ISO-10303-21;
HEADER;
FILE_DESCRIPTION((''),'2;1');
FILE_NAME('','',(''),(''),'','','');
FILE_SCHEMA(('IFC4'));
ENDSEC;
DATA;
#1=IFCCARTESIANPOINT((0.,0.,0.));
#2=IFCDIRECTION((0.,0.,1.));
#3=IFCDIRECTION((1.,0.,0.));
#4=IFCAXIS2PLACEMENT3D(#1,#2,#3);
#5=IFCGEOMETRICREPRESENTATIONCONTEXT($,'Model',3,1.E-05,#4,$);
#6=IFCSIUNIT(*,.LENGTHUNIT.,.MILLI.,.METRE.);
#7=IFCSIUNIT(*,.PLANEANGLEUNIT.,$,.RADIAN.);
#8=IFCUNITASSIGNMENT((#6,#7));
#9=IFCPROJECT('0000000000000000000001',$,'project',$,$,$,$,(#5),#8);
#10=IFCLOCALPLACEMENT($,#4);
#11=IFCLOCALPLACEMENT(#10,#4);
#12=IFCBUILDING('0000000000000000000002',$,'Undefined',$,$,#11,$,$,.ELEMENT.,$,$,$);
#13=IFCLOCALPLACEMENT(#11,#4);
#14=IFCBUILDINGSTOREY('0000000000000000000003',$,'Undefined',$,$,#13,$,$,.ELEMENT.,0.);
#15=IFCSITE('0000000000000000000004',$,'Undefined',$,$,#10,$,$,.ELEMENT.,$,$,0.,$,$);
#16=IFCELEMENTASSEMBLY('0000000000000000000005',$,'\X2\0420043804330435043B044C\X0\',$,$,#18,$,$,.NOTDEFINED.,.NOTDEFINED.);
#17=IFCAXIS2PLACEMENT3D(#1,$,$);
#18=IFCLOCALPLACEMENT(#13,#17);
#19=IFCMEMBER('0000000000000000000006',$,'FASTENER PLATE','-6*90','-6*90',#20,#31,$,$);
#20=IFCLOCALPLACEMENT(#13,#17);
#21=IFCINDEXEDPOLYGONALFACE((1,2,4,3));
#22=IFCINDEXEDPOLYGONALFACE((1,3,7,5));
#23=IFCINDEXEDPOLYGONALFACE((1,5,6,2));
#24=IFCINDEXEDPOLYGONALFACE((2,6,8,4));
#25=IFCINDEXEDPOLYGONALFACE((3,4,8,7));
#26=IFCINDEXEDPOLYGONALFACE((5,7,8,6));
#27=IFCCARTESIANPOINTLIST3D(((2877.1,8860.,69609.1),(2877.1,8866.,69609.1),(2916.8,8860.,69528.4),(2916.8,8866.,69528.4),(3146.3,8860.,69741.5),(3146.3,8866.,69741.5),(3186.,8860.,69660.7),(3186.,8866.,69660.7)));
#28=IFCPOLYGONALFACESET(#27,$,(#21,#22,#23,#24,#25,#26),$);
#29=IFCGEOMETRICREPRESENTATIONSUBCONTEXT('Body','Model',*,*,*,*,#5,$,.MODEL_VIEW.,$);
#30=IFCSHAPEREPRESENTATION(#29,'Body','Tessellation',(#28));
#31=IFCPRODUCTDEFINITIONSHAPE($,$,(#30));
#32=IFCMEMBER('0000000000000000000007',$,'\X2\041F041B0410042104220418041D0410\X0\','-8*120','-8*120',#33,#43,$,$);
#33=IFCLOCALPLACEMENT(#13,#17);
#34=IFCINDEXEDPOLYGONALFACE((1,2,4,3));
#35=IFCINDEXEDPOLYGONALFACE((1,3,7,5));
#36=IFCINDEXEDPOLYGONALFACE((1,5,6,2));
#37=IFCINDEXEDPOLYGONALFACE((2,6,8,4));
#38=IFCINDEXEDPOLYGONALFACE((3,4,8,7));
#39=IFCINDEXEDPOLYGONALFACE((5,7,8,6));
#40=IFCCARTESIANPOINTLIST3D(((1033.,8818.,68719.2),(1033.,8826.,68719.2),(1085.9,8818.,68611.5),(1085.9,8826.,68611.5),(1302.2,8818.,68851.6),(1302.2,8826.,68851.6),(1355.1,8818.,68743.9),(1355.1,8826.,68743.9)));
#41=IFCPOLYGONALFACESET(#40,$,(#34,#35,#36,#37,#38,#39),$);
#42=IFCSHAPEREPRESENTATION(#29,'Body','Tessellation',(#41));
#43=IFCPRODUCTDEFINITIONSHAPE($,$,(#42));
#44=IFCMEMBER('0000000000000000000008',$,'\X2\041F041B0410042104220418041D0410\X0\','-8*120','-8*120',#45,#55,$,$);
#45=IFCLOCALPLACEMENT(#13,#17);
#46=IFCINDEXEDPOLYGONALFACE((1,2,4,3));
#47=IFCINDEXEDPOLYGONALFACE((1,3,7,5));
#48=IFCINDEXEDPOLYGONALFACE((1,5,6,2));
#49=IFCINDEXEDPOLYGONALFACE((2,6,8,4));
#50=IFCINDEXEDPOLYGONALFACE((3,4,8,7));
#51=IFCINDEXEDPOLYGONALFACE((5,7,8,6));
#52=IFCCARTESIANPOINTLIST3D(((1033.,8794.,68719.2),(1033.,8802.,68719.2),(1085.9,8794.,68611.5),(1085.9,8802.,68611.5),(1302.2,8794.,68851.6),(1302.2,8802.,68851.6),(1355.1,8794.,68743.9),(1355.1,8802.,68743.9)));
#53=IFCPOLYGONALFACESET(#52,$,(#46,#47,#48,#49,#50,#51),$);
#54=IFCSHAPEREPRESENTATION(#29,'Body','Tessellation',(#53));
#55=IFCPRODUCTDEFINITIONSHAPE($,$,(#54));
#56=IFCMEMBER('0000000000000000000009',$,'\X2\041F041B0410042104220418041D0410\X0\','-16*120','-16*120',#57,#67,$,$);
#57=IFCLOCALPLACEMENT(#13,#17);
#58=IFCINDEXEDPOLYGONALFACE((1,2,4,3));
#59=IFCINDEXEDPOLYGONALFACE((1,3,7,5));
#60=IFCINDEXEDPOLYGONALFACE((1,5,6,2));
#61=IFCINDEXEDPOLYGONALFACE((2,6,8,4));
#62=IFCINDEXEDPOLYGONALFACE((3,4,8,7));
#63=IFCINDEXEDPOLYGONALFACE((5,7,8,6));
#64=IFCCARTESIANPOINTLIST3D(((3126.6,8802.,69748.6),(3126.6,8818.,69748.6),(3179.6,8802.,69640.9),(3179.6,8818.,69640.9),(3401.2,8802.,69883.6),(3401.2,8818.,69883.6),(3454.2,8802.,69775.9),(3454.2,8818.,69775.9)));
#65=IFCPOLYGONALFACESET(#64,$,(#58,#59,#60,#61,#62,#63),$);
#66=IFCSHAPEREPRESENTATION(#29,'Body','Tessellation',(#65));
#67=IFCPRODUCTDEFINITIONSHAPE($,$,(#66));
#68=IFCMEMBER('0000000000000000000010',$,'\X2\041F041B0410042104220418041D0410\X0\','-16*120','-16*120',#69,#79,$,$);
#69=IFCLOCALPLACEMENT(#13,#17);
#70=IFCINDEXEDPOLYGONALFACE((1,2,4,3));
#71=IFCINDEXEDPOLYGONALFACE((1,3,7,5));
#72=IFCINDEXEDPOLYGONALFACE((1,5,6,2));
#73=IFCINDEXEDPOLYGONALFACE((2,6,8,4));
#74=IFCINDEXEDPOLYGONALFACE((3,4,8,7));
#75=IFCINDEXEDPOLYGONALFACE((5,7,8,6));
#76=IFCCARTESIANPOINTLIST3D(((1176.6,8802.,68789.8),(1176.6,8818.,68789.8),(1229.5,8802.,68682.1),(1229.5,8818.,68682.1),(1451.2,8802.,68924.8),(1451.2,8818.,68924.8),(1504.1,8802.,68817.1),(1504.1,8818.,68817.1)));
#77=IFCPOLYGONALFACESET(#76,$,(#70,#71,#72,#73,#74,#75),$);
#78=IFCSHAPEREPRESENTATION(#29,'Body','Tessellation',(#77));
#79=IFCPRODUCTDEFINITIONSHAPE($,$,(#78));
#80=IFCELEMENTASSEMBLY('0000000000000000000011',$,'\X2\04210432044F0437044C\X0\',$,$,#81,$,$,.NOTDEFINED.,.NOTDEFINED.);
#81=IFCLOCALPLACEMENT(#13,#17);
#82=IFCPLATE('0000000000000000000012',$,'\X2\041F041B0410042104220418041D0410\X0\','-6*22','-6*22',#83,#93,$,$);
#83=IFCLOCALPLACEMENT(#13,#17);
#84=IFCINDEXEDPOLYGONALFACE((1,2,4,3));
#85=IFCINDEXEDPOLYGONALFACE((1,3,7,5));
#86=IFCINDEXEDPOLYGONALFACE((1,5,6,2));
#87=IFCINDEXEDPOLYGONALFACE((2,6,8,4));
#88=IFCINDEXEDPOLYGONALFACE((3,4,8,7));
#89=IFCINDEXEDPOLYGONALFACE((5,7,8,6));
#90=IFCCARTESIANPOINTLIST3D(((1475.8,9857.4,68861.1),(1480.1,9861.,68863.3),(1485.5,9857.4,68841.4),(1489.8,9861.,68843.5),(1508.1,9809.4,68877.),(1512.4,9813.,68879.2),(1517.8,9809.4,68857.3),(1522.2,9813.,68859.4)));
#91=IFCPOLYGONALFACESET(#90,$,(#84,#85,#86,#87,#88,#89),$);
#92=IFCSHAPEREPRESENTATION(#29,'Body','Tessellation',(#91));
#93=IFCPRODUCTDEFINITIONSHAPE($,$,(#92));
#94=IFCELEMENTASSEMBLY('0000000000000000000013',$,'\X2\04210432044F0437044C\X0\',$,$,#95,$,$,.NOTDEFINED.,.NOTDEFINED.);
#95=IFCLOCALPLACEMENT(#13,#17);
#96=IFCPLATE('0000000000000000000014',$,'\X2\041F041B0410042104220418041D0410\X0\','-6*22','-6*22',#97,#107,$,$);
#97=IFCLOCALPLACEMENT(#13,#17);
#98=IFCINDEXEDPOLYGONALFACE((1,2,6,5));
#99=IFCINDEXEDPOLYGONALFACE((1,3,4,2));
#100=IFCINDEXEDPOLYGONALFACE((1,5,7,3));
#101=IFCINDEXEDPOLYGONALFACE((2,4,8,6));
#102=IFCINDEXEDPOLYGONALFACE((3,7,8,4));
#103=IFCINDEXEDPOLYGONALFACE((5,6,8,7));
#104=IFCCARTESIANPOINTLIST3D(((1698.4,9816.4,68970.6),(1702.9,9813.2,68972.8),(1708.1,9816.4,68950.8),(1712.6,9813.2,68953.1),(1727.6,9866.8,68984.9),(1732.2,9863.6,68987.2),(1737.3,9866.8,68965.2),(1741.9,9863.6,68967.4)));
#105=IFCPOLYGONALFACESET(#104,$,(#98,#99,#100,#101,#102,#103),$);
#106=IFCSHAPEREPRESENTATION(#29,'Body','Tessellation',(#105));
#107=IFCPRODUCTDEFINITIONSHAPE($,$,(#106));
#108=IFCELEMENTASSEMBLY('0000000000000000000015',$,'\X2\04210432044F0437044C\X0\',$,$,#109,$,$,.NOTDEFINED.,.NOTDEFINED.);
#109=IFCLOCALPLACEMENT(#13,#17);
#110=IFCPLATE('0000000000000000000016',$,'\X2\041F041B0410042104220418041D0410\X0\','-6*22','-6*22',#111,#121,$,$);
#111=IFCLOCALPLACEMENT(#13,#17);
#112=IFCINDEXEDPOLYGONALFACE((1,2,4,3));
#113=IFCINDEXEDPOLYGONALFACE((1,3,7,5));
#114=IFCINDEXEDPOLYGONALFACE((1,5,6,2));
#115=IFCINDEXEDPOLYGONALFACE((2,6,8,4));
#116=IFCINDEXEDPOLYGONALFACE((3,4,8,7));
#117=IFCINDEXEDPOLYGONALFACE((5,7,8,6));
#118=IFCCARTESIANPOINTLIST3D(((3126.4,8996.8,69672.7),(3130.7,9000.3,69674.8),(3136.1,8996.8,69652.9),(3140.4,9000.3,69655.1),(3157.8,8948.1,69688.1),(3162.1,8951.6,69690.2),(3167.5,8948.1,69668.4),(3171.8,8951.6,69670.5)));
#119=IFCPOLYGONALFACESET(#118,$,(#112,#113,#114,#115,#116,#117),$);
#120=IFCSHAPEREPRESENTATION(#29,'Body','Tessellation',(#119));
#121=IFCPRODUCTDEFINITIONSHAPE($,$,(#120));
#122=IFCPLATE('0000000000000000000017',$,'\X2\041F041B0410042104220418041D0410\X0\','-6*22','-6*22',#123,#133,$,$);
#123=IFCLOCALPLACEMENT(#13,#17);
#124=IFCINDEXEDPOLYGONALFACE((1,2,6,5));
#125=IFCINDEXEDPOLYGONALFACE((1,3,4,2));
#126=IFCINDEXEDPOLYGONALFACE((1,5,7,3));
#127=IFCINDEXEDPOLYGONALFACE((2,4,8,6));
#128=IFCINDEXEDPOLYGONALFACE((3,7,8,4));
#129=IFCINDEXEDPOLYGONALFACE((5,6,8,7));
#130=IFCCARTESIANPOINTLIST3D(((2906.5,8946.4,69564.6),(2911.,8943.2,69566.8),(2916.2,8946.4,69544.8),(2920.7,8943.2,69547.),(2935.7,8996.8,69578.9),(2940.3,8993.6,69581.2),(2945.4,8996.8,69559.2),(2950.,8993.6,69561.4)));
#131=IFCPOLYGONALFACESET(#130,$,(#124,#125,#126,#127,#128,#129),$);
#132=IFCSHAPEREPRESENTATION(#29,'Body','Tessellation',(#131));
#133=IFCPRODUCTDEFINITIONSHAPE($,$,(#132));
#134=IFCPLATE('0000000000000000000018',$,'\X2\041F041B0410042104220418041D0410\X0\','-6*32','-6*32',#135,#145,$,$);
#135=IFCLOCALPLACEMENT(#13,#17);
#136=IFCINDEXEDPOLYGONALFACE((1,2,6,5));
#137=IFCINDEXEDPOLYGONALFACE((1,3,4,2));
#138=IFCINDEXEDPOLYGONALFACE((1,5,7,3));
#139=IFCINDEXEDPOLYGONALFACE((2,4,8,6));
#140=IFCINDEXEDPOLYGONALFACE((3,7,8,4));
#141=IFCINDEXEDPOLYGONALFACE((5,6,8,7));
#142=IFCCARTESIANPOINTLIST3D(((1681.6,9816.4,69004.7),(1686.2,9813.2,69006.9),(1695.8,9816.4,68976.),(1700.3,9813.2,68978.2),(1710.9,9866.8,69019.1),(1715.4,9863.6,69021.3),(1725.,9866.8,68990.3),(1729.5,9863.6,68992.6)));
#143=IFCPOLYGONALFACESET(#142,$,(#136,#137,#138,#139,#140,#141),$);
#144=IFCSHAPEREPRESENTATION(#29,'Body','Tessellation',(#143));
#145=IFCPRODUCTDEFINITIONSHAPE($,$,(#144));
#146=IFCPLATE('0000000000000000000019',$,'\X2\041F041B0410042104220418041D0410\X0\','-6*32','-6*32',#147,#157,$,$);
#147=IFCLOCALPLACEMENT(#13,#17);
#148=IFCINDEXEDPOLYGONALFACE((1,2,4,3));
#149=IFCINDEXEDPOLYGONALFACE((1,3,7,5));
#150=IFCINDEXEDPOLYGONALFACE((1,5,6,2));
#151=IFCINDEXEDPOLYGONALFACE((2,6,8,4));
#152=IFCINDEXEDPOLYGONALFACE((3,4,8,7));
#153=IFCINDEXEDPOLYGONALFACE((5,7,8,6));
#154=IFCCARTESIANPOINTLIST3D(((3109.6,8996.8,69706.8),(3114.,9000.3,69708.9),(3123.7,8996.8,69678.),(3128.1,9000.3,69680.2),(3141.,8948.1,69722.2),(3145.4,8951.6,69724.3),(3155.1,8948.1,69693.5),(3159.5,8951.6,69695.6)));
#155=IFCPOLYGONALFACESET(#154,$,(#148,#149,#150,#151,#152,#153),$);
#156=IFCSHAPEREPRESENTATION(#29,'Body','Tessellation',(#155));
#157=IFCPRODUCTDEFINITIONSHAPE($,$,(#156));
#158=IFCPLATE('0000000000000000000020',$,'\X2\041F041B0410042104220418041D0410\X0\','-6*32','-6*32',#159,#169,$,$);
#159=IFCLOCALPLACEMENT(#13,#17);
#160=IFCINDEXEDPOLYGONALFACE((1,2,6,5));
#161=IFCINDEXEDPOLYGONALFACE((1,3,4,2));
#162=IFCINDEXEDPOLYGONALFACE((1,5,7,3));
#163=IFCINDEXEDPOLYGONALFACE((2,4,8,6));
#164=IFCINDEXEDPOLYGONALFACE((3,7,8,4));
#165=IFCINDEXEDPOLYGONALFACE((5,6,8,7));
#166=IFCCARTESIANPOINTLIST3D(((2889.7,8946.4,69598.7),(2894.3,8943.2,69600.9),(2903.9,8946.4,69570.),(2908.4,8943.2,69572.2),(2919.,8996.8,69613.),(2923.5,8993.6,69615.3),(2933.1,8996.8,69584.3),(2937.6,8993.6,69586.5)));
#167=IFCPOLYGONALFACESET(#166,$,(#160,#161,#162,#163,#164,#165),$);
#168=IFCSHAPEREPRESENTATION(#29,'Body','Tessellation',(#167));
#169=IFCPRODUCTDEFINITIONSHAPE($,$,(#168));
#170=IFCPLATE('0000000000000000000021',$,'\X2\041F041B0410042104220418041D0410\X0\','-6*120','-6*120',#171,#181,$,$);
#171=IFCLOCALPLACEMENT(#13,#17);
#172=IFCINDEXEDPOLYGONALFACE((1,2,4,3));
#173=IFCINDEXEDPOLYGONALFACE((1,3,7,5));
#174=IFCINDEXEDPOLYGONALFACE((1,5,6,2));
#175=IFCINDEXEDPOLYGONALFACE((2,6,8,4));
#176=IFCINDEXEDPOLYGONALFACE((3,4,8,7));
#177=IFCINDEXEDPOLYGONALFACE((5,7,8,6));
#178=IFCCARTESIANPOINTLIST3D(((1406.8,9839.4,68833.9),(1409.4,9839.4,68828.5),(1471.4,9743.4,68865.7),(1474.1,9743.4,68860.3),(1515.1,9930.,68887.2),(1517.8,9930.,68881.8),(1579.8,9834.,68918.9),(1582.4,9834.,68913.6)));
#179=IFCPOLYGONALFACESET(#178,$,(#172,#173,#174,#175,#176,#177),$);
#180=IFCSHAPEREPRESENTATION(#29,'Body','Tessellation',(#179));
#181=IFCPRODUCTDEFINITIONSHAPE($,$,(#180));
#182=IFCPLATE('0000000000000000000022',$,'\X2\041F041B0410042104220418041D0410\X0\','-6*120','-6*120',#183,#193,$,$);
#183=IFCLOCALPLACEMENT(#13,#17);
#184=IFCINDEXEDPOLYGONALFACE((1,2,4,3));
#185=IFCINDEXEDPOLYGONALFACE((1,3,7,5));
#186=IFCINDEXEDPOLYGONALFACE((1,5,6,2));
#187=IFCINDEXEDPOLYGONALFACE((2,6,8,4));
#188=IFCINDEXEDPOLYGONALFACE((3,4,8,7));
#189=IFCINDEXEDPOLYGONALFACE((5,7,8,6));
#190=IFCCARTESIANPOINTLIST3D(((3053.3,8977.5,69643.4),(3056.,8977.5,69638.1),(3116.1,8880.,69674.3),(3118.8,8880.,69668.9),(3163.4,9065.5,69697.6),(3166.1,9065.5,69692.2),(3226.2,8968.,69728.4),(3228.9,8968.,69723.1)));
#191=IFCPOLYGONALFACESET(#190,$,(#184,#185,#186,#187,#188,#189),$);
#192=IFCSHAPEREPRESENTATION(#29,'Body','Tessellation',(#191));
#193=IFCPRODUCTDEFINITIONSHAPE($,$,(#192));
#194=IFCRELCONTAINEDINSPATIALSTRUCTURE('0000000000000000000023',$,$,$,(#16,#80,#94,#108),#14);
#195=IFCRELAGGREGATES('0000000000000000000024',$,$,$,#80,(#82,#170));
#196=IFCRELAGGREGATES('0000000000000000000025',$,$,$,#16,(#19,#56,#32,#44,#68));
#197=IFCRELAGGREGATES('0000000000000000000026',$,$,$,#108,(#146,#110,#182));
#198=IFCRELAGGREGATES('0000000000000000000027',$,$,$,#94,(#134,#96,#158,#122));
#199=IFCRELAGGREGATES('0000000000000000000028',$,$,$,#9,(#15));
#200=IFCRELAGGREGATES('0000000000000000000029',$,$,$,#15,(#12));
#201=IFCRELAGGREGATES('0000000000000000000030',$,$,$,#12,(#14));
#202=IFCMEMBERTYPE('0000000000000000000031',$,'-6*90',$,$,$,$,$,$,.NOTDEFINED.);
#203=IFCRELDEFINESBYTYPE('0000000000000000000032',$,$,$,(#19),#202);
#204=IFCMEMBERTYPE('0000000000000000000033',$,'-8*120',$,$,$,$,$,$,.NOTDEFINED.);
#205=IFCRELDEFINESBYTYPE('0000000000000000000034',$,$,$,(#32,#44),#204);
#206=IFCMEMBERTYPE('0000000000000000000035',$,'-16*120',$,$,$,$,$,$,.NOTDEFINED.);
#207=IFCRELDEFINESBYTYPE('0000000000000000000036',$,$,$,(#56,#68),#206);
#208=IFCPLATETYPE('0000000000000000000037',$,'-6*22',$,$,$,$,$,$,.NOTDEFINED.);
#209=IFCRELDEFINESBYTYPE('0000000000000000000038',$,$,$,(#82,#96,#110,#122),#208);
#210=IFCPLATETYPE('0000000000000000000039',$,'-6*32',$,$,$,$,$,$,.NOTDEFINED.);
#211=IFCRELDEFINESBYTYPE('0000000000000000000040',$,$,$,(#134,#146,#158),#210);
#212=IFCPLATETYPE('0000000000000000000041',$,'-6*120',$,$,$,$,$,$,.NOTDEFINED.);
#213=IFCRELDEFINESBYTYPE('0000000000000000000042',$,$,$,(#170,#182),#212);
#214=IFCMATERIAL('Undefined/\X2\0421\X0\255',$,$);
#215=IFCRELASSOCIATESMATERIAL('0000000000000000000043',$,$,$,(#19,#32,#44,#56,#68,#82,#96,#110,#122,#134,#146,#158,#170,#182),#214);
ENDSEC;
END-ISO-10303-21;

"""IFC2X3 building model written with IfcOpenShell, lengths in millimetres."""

from ifc_helpers import new_model, si_unit, frame, origin_with_axes, origin_2d_with_axis, place, context, subcontext, project, spatial, polyline, rectangle, outline, extrude, material, type_object, element, aggregate, save


model = new_model("IFC2X3")

# Units and contexts
model_context = context("Model", 3, precision=1e-05, world=origin_with_axes())
body_context = subcontext(model_context, "Body", "Model", "MODEL_VIEW")
ifc_project = project(units=[si_unit("LENGTHUNIT", "METRE", prefix="MILLI"), si_unit("PLANEANGLEUNIT", "RADIAN")], contexts=[model_context])

# Site, building, storey
site_placement = place(None, origin_with_axes())
site = spatial("IfcSite", under=ifc_project, at=site_placement, Name="Undefined", CompositionType="ELEMENT", RefElevation=0.0)
building_placement = place(site_placement, origin_with_axes())
building = spatial("IfcBuilding", under=site, at=building_placement, Name="Undefined", CompositionType="ELEMENT")
storey_placement = place(building_placement, origin_with_axes())
storey = spatial("IfcBuildingStorey", under=building, at=storey_placement, Name="Undefined", CompositionType="ELEMENT", Elevation=0.0)

# Element assembly, members
assembly_1_placement = place(storey_placement, origin_with_axes())
assembly_1 = element("IfcElementAssembly", 1, at=assembly_1_placement, inside=storey, Name="Ригель", AssemblyPlace="NOTDEFINED", PredefinedType="NOTDEFINED")
ifc_material_1 = material(Name="Undefined/С255")
member_type_1 = type_object("IfcMemberType", Name="-6*90", PredefinedType="NOTDEFINED")
member_1_placement = place(assembly_1_placement, frame((2896.9, 8863.0, 69568.8), z_axis=(-0.441224, 0.0, 0.897397), x_axis=(0.897397, 0.0, 0.441224)))
member_1 = element("IfcMember", 2, at=member_1_placement, type_object=member_type_1, material=ifc_material_1, Name="FASTENER PLATE", Description="-6*90", ObjectType="-6*90", context=body_context, shape_type="SweptSolid", body=[
    extrude(rectangle(XDim=6.0, YDim=90.0, at=origin_2d_with_axis()), frame((300.0, 0.0, 0.0), z_axis=(-1.0, 0.0, 0.0), x_axis=(0.0, -1.0, 0.0)), (0.0, 0.0, 1.0), 300.0),
])
member_type_2 = type_object("IfcMemberType", Name="-8*120", PredefinedType="NOTDEFINED")
member_2_placement = place(assembly_1_placement, frame((1059.5, 8822.0, 68665.3), z_axis=(0.441221, 0.0, -0.897399), x_axis=(0.897399, 0.0, 0.441221)))
member_2 = element("IfcMember", 3, at=member_2_placement, type_object=member_type_2, material=ifc_material_1, Name="ПЛАСТИНА", Description="-8*120", ObjectType="-8*120", context=body_context, shape_type="SweptSolid", body=[
    extrude(rectangle(XDim=8.0, YDim=120.0, at=origin_2d_with_axis()), frame((300.0, 0.0, 0.0), z_axis=(-1.0, 0.0, 0.0), x_axis=(0.0, -1.0, 0.0)), (0.0, 0.0, 1.0), 300.0),
])
member_3_placement = place(assembly_1_placement, frame((1059.5, 8798.0, 68665.3), z_axis=(0.441221, 0.0, -0.897399), x_axis=(0.897399, 0.0, 0.441221)))
member_3 = element("IfcMember", 4, at=member_3_placement, type_object=member_type_2, material=ifc_material_1, Name="ПЛАСТИНА", Description="-8*120", ObjectType="-8*120", context=body_context, shape_type="SweptSolid", body=[
    extrude(rectangle(XDim=8.0, YDim=120.0, at=origin_2d_with_axis()), frame((300.0, 0.0, 0.0), z_axis=(-1.0, 0.0, 0.0), x_axis=(0.0, -1.0, 0.0)), (0.0, 0.0, 1.0), 300.0),
])
member_type_3 = type_object("IfcMemberType", Name="-16*120", PredefinedType="NOTDEFINED")
member_4_placement = place(assembly_1_placement, frame((3153.1, 8810.0, 69694.7), z_axis=(0.441221, 0.0, -0.897399), x_axis=(0.897399, 0.0, 0.441221)))
member_4 = element("IfcMember", 5, at=member_4_placement, type_object=member_type_3, material=ifc_material_1, Name="ПЛАСТИНА", Description="-16*120", ObjectType="-16*120", context=body_context, shape_type="SweptSolid", body=[
    extrude(rectangle(XDim=16.0, YDim=120.0, at=origin_2d_with_axis()), frame((306.0, 0.0, 0.0), z_axis=(-1.0, 0.0, 0.0), x_axis=(0.0, -1.0, 0.0)), (0.0, 0.0, 1.0), 306.0),
])
member_5_placement = place(assembly_1_placement, frame((1203.0, 8810.0, 68735.9), z_axis=(0.441221, 0.0, -0.897399), x_axis=(0.897399, 0.0, 0.441221)))
member_5 = element("IfcMember", 6, at=member_5_placement, type_object=member_type_3, material=ifc_material_1, Name="ПЛАСТИНА", Description="-16*120", ObjectType="-16*120", context=body_context, shape_type="SweptSolid", body=[
    extrude(rectangle(XDim=16.0, YDim=120.0, at=origin_2d_with_axis()), frame((306.0, 0.0, 0.0), z_axis=(-1.0, 0.0, 0.0), x_axis=(0.0, -1.0, 0.0)), (0.0, 0.0, 1.0), 306.0),
])

# Element assemblies, plates
assembly_2_placement = place(storey_placement, origin_with_axes())
assembly_2 = element("IfcElementAssembly", 7, at=assembly_2_placement, inside=storey, Name="Связь", AssemblyPlace="NOTDEFINED", PredefinedType="NOTDEFINED")
plate_type_1 = type_object("IfcPlateType", Name="-6*22", PredefinedType="NOTDEFINED")
plate_1_placement = place(assembly_2_placement, frame((1478.0, 9859.2, 68862.2), z_axis=(-0.717731, -0.600279, -0.352884), x_axis=(0.441222, -0.000002, -0.897398)))
plate_1 = element("IfcPlate", 8, at=plate_1_placement, type_object=plate_type_1, material=ifc_material_1, Name="ПЛАСТИНА", Description="-6*22", ObjectType="-6*22", context=body_context, shape_type="SweptSolid", body=[
    extrude(outline(polyline([(0.0, 0.0), (22.0, 0.0), (22.0, 60.0), (0.0, 60.0), (0.0, 0.0)])), frame((0.0, 0.0, -3.0), z_axis=(0.0, 0.0, 1.0), x_axis=(1.0, 0.0, 0.0)), (0.0, 0.0, 1.0), 6.0),
])
assembly_3_placement = place(storey_placement, origin_with_axes())
assembly_3 = element("IfcElementAssembly", 9, at=assembly_3_placement, inside=storey, Name="Связь", AssemblyPlace="NOTDEFINED", PredefinedType="NOTDEFINED")
plate_2_placement = place(assembly_3_placement, frame((1700.7, 9814.8, 68971.7), z_axis=(0.753715, -0.542758, 0.370577), x_axis=(0.441222, 0.000001, -0.897398)))
plate_2 = element("IfcPlate", 10, at=plate_2_placement, type_object=plate_type_1, material=ifc_material_1, Name="ПЛАСТИНА", Description="-6*22", ObjectType="-6*22", context=body_context, shape_type="SweptSolid", body=[
    extrude(outline(polyline([(0.0, 0.0), (22.0, 0.0), (22.0, 60.0), (0.0, 60.0), (0.0, 0.0)])), frame((0.0, 0.0, -3.0), z_axis=(0.0, 0.0, 1.0), x_axis=(1.0, 0.0, 0.0)), (0.0, 0.0, 1.0), 6.0),
])
assembly_4_placement = place(storey_placement, origin_with_axes())
assembly_4 = element("IfcElementAssembly", 11, at=assembly_4_placement, inside=storey, Name="Связь", AssemblyPlace="NOTDEFINED", PredefinedType="NOTDEFINED")
plate_3_placement = place(assembly_4_placement, frame((3159.9, 8949.8, 69689.2), z_axis=(0.729105, 0.58301, 0.358477), x_axis=(0.441222, -0.000002, -0.897398)))
plate_3 = element("IfcPlate", 12, at=plate_3_placement, type_object=plate_type_1, material=ifc_material_1, Name="ПЛАСТИНА", Description="-6*22", ObjectType="-6*22", context=body_context, shape_type="SweptSolid", body=[
    extrude(outline(polyline([(0.0, 0.0), (22.0, 0.0), (22.0, 60.0), (0.0, 60.0), (0.0, 0.0)])), frame((0.0, 0.0, -3.0), z_axis=(0.0, 0.0, 1.0), x_axis=(1.0, 0.0, 0.0)), (0.0, 0.0, 1.0), 6.0),
])

# Plates
plate_4_placement = place(assembly_3_placement, frame((2938.0, 8995.2, 69580.0), z_axis=(-0.753715, 0.542758, -0.370577), x_axis=(0.441222, 0.000001, -0.897398)))
plate_4 = element("IfcPlate", 13, at=plate_4_placement, type_object=plate_type_1, material=ifc_material_1, Name="ПЛАСТИНА", Description="-6*22", ObjectType="-6*22", context=body_context, shape_type="SweptSolid", body=[
    extrude(outline(polyline([(0.0, 0.0), (22.0, 0.0), (22.0, 60.0), (0.0, 60.0), (0.0, 0.0)])), frame((0.0, 0.0, -3.0), z_axis=(0.0, 0.0, 1.0), x_axis=(1.0, 0.0, 0.0)), (0.0, 0.0, 1.0), 6.0),
])
plate_type_2 = type_object("IfcPlateType", Name="-6*32", PredefinedType="NOTDEFINED")
plate_5_placement = place(assembly_3_placement, frame((1683.9, 9814.8, 69005.8), z_axis=(0.753715, -0.542758, 0.370577), x_axis=(0.441222, 0.000001, -0.897398)))
plate_5 = element("IfcPlate", 14, at=plate_5_placement, type_object=plate_type_2, material=ifc_material_1, Name="ПЛАСТИНА", Description="-6*32", ObjectType="-6*32", context=body_context, shape_type="SweptSolid", body=[
    extrude(outline(polyline([(0.0, 0.0), (32.0, 0.0), (32.0, 60.0), (0.0, 60.0), (0.0, 0.0)])), frame((0.0, 0.0, -3.0), z_axis=(0.0, 0.0, 1.0), x_axis=(1.0, 0.0, 0.0)), (0.0, 0.0, 1.0), 6.0),
])
plate_6_placement = place(assembly_4_placement, frame((3143.2, 8949.8, 69723.3), z_axis=(0.729105, 0.58301, 0.358477), x_axis=(0.441222, -0.000002, -0.897398)))
plate_6 = element("IfcPlate", 15, at=plate_6_placement, type_object=plate_type_2, material=ifc_material_1, Name="ПЛАСТИНА", Description="-6*32", ObjectType="-6*32", context=body_context, shape_type="SweptSolid", body=[
    extrude(outline(polyline([(0.0, 0.0), (32.0, 0.0), (32.0, 60.0), (0.0, 60.0), (0.0, 0.0)])), frame((0.0, 0.0, -3.0), z_axis=(0.0, 0.0, 1.0), x_axis=(1.0, 0.0, 0.0)), (0.0, 0.0, 1.0), 6.0),
])
plate_7_placement = place(assembly_3_placement, frame((2921.2, 8995.2, 69614.1), z_axis=(-0.753715, 0.542758, -0.370577), x_axis=(0.441222, 0.000001, -0.897398)))
plate_7 = element("IfcPlate", 16, at=plate_7_placement, type_object=plate_type_2, material=ifc_material_1, Name="ПЛАСТИНА", Description="-6*32", ObjectType="-6*32", context=body_context, shape_type="SweptSolid", body=[
    extrude(outline(polyline([(0.0, 0.0), (32.0, 0.0), (32.0, 60.0), (0.0, 60.0), (0.0, 0.0)])), frame((0.0, 0.0, -3.0), z_axis=(0.0, 0.0, 1.0), x_axis=(1.0, 0.0, 0.0)), (0.0, 0.0, 1.0), 6.0),
])
plate_type_3 = type_object("IfcPlateType", Name="-6*120", PredefinedType="NOTDEFINED")
plate_8_placement = place(assembly_2_placement, frame((1581.1, 9834.0, 68916.3), z_axis=(-0.441222, 0.000002, 0.897398), x_axis=(-0.538688, 0.799791, -0.264857)))
plate_8 = element("IfcPlate", 17, at=plate_8_placement, type_object=plate_type_3, material=ifc_material_1, Name="ПЛАСТИНА", Description="-6*120", ObjectType="-6*120", context=body_context, shape_type="SweptSolid", body=[
    extrude(outline(polyline([(0.0, 0.0), (120.0, 0.0), (120.0, 151.0), (0.0, 151.0), (0.0, 0.0)])), frame((0.0, 0.0, -3.0), z_axis=(0.0, 0.0, 1.0), x_axis=(1.0, 0.0, 0.0)), (0.0, 0.0, 1.0), 6.0),
])
aggregate(assembly_2, [plate_1, plate_8])
plate_9_placement = place(assembly_4_placement, frame((3054.7, 8977.5, 69640.7), z_axis=(-0.441222, 0.000002, 0.897398), x_axis=(0.523191, -0.812465, 0.257238)))
plate_9 = element("IfcPlate", 18, at=plate_9_placement, type_object=plate_type_3, material=ifc_material_1, Name="ПЛАСТИНА", Description="-6*120", ObjectType="-6*120", context=body_context, shape_type="SweptSolid", body=[
    extrude(outline(polyline([(0.0, 0.0), (120.0, 0.0), (120.0, 151.0), (0.0, 151.0), (0.0, 0.0)])), frame((0.0, 0.0, -3.0), z_axis=(0.0, 0.0, 1.0), x_axis=(1.0, 0.0, 0.0)), (0.0, 0.0, 1.0), 6.0),
])

aggregate(assembly_1, [member_1, member_4, member_2, member_3, member_5])
aggregate(assembly_4, [plate_6, plate_3, plate_9])
aggregate(assembly_3, [plate_5, plate_2, plate_7, plate_4])

save(model, "model.ifc")
